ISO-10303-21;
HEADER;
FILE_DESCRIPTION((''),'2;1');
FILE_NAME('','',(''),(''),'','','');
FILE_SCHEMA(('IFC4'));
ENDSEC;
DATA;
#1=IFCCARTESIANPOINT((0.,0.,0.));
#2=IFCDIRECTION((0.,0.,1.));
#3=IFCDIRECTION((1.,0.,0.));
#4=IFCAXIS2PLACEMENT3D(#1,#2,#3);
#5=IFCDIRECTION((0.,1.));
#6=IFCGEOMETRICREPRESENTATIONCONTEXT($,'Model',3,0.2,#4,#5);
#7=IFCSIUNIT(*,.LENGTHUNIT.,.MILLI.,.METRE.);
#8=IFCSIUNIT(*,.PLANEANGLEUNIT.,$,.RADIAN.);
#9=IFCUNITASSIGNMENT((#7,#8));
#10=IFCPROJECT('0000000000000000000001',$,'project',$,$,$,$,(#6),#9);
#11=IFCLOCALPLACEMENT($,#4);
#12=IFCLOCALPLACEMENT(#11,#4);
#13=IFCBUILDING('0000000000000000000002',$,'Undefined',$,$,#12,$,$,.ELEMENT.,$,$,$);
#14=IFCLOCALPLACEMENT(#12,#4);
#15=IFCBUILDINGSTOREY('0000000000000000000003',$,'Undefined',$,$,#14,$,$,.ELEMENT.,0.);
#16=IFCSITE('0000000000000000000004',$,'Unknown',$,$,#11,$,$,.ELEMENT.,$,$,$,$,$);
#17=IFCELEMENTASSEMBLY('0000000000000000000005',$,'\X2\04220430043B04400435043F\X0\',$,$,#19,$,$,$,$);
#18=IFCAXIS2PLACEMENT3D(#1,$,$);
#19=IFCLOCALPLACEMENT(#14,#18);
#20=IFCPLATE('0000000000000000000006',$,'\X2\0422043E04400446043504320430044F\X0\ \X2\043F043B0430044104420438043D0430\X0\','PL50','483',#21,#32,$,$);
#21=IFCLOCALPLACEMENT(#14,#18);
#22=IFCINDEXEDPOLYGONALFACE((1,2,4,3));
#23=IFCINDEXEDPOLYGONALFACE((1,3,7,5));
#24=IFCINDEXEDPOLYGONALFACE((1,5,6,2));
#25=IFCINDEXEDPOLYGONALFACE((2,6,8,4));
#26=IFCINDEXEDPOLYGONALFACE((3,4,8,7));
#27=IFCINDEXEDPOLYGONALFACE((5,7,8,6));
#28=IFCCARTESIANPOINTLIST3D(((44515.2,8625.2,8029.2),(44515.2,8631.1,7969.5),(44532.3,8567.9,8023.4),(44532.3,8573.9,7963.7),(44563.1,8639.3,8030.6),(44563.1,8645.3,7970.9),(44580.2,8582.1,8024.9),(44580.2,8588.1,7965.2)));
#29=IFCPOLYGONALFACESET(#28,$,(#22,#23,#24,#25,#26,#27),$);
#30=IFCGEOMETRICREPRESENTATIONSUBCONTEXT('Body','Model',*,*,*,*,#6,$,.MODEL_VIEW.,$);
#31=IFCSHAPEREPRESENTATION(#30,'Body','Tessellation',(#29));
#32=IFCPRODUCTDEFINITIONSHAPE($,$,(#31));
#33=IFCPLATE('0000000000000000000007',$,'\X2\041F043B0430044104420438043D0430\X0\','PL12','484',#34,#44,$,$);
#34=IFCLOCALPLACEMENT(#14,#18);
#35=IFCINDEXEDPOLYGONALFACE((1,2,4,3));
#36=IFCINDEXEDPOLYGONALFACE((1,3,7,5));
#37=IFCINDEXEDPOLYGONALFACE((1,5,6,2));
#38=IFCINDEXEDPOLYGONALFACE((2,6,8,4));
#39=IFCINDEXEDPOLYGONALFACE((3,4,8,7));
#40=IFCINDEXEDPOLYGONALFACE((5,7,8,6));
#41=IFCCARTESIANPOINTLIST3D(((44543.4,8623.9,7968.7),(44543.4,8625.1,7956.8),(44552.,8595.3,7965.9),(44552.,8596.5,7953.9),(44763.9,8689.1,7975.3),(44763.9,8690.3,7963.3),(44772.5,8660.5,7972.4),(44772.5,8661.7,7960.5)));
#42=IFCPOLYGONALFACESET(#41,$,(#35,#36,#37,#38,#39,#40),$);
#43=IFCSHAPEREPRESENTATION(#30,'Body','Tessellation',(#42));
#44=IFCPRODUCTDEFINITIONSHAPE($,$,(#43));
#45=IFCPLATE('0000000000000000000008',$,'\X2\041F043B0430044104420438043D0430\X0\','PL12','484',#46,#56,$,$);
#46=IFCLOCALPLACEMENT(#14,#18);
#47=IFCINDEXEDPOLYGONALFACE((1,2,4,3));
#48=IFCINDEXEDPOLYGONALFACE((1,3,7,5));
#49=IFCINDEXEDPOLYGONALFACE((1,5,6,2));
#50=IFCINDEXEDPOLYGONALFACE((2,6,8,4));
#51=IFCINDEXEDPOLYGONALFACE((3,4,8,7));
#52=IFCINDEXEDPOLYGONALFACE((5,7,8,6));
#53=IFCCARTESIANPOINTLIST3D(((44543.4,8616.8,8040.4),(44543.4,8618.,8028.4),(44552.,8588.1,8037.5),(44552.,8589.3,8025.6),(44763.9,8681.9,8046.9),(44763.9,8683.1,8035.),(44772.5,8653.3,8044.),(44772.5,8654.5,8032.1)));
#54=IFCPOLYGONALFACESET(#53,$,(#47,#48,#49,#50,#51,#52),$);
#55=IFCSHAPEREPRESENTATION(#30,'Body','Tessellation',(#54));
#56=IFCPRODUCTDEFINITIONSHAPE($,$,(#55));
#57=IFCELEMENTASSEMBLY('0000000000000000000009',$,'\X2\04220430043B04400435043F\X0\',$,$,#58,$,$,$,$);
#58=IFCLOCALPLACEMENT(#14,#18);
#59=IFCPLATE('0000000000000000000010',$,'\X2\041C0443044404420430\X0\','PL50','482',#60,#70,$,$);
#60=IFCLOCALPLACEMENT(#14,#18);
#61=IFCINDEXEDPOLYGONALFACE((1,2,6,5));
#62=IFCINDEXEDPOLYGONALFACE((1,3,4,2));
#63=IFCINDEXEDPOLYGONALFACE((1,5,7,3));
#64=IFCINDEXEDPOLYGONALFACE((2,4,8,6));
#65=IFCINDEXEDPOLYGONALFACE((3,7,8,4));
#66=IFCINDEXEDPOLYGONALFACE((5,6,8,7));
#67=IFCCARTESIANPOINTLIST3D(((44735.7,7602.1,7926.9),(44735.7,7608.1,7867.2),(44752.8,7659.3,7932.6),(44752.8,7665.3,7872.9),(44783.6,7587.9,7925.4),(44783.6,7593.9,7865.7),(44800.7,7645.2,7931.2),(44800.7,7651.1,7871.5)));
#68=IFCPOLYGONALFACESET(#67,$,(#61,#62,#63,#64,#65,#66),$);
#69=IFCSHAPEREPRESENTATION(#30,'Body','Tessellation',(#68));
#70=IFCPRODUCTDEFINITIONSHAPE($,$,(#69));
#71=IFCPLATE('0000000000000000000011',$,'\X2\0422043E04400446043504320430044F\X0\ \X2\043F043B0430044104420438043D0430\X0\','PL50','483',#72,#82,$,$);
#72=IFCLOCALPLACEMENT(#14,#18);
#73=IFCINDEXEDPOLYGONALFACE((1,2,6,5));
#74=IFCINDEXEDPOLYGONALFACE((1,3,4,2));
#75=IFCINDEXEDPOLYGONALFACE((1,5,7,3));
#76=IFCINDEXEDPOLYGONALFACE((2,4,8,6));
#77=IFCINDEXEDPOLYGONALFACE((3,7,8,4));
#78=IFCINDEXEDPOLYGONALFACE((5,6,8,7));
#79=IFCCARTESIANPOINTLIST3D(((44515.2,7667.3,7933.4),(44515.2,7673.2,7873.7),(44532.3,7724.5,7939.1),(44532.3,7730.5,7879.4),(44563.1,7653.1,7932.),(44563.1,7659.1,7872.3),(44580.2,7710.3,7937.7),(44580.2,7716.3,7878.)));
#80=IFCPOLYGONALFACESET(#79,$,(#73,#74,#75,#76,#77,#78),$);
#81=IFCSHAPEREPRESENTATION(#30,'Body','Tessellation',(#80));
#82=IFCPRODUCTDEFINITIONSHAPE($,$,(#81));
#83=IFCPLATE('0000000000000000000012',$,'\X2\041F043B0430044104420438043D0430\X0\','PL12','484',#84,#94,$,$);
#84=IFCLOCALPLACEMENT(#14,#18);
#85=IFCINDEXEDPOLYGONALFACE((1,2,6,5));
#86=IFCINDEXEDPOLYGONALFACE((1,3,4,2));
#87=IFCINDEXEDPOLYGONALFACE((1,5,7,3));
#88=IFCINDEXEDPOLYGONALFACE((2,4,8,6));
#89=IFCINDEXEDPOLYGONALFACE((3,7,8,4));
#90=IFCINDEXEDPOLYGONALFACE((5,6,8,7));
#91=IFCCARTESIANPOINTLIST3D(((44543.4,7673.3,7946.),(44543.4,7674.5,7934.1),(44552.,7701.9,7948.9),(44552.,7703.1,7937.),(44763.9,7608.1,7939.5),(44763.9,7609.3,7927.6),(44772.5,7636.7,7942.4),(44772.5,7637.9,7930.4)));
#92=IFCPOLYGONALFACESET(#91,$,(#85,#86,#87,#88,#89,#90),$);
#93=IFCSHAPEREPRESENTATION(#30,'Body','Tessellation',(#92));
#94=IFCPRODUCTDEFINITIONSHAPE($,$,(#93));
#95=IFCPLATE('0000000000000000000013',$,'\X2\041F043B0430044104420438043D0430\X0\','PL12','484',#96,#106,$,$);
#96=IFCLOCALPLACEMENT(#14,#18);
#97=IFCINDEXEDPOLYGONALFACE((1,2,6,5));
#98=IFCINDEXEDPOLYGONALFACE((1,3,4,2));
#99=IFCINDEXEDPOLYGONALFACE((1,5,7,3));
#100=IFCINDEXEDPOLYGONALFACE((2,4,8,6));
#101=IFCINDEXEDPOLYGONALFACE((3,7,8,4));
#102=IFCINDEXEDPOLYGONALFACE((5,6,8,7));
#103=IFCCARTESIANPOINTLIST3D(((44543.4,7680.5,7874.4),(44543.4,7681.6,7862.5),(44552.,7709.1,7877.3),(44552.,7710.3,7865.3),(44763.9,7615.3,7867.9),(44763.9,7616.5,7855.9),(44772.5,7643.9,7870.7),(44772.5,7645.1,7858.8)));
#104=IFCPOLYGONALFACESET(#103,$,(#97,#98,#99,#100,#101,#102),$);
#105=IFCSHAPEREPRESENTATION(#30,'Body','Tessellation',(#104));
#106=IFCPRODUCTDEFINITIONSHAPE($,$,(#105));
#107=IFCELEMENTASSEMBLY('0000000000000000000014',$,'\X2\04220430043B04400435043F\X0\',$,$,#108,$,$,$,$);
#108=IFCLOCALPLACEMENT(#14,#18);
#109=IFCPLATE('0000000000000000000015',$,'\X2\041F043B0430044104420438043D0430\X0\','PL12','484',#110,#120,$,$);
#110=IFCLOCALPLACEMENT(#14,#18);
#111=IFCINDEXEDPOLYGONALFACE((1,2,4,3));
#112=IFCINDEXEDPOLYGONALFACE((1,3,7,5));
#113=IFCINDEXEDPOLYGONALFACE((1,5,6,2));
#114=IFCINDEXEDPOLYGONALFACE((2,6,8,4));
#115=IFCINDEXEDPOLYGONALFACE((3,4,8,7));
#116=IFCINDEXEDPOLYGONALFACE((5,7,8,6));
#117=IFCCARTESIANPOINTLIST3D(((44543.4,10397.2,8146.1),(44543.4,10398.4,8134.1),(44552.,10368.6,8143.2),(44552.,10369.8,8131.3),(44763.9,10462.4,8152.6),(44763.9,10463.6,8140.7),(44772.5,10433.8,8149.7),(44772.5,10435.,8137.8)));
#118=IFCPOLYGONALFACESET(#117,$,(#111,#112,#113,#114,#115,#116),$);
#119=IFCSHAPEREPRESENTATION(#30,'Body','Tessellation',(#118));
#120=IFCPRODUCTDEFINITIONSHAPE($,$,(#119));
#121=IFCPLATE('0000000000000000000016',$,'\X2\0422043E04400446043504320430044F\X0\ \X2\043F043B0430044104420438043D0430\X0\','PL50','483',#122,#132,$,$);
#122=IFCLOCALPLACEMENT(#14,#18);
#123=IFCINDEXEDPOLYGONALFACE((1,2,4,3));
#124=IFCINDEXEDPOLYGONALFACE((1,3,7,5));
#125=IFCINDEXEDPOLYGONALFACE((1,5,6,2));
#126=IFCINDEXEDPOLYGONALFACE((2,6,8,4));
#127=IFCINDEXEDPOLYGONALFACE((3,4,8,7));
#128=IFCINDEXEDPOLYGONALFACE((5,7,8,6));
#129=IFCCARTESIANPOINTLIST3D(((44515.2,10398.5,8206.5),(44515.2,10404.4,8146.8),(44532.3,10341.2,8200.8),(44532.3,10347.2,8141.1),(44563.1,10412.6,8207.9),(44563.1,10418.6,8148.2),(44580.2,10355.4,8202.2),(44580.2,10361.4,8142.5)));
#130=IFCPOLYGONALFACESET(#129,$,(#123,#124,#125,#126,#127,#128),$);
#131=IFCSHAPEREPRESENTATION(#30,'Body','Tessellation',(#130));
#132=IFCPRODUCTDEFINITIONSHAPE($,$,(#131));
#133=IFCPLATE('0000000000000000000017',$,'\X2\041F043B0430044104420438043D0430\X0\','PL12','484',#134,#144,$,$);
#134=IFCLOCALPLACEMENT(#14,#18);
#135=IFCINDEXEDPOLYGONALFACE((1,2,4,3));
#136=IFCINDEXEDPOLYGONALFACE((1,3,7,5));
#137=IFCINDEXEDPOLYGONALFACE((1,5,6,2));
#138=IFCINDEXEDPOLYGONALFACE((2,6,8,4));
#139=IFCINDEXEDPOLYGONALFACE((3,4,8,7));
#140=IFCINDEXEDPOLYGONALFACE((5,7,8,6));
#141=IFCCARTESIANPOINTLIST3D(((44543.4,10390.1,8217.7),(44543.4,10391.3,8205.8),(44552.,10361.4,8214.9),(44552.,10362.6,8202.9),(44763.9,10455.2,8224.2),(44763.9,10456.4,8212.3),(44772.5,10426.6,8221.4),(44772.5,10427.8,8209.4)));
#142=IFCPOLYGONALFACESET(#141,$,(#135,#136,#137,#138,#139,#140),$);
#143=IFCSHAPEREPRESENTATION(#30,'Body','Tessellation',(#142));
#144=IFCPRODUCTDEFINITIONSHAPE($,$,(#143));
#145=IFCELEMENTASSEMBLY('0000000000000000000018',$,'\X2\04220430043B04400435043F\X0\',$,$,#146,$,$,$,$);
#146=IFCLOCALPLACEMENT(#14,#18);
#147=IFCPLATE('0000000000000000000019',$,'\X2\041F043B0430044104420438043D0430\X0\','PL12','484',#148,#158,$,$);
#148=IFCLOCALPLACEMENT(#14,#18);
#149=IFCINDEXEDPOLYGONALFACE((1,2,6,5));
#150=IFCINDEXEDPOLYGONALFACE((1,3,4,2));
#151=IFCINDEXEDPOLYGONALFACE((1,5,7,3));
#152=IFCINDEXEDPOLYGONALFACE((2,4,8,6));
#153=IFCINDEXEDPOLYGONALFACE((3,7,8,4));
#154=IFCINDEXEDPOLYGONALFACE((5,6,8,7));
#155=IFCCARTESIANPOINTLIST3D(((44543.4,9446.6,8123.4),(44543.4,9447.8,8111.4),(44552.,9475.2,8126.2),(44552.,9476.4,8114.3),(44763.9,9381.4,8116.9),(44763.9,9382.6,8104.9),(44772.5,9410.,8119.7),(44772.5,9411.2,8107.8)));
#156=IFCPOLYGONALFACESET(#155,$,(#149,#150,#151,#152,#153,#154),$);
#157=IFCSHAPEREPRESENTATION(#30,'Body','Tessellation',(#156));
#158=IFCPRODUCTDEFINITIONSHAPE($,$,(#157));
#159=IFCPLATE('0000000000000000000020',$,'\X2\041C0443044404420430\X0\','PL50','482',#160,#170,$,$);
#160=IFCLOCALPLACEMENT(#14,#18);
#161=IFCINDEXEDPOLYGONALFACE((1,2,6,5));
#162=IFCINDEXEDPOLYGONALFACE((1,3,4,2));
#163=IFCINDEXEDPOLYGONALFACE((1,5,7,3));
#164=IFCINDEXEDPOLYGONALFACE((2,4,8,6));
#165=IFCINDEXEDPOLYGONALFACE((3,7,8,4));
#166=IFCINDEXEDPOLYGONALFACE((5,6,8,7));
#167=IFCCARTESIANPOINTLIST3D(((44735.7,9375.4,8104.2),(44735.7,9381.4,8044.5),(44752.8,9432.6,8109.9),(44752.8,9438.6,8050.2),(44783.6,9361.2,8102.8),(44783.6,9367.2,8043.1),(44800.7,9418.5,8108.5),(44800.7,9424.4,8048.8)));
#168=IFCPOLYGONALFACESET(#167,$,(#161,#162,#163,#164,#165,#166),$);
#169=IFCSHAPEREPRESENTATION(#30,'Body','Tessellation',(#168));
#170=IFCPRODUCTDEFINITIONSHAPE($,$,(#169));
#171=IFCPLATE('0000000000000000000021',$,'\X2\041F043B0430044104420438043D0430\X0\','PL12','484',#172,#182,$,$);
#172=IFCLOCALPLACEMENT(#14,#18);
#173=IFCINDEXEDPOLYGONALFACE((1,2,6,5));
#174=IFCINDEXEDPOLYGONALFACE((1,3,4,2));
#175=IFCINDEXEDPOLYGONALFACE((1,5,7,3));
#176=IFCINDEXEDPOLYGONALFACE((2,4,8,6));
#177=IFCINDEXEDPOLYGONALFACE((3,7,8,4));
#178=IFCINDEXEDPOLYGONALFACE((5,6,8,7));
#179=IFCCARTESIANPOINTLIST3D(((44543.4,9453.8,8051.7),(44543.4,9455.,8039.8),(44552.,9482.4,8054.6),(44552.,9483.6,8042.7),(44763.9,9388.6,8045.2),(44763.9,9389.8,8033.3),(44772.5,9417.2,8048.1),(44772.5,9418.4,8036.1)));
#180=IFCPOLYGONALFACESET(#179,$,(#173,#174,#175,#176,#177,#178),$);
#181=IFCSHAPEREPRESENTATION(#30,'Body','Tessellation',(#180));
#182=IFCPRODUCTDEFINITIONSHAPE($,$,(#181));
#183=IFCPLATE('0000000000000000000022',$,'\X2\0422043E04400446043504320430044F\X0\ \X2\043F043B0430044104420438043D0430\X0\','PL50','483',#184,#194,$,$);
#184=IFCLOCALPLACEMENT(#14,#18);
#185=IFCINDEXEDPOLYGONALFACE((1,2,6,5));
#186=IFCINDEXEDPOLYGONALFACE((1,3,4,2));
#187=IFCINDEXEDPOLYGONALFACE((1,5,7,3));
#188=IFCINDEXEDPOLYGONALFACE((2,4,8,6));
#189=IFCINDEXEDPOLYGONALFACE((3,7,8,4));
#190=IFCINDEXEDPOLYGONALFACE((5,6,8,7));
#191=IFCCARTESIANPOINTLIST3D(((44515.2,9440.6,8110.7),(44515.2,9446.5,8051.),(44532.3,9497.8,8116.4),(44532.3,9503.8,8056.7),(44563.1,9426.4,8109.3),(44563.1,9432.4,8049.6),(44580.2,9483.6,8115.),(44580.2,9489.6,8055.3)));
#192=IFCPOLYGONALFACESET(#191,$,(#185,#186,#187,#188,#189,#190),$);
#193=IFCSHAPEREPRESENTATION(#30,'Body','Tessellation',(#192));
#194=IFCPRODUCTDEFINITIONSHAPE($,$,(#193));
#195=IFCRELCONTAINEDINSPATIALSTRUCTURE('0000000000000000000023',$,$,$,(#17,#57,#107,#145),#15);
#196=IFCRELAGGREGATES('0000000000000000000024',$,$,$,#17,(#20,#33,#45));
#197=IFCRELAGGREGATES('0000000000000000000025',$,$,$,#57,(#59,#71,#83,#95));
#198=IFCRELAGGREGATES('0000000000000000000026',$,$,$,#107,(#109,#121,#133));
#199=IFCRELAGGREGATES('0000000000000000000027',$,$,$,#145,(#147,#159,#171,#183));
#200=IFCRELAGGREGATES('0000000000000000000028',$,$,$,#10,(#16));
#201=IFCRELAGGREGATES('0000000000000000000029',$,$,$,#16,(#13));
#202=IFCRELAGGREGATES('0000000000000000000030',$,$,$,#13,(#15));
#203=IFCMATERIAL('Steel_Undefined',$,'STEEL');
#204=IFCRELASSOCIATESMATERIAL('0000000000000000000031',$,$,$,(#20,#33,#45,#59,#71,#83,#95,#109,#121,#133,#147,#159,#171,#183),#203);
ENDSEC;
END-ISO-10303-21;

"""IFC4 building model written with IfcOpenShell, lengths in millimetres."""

from ifc_helpers import new_model, si_unit, direction, frame, origin_with_axes, place, context, subcontext, project, spatial, line, indexed_curve, outline, extrude, material, element, aggregate, save


model = new_model("IFC4")

# Units and contexts
model_context = context("Model", 3, precision=0.2, world=origin_with_axes(), true_north=direction((0.0, 1.0)))
body_context = subcontext(model_context, "Body", "Model", "MODEL_VIEW")
ifc_project = project(units=[si_unit("LENGTHUNIT", "METRE", prefix="MILLI"), si_unit("PLANEANGLEUNIT", "RADIAN")], contexts=[model_context])

# Site, building, storey
site_placement = place(None, origin_with_axes())
site = spatial("IfcSite", under=ifc_project, at=site_placement, Name="Unknown", CompositionType="ELEMENT")
building_placement = place(site_placement, origin_with_axes())
building = spatial("IfcBuilding", under=site, at=building_placement, Name="Undefined", CompositionType="ELEMENT")
storey_placement = place(building_placement, origin_with_axes())
storey = spatial("IfcBuildingStorey", under=building, at=storey_placement, Name="Undefined", CompositionType="ELEMENT", Elevation=0.0)

# Element assemblies, plates
assembly_1_placement = place(storey_placement, frame((44776.7, 8640.2, 8030.7), z_axis=(-0.958608, -0.283317, -0.028332), x_axis=(-0.28473, 0.95385, 0.095385)))
assembly_1 = element("IfcElementAssembly", 1, at=assembly_1_placement, inside=storey, Name="Талреп")
ifc_material_1 = material(Name="Steel_Undefined", Category="STEEL")
plate_1_placement = place(assembly_1_placement, frame((0.0, 0.0, 230.0), z_axis=(0.0, 0.0, 1.0), x_axis=(1.0, 0.0, 0.0)))
plate_1 = element("IfcPlate", 2, at=plate_1_placement, material=ifc_material_1, Name="Торцевая пластина", Description="PL50", ObjectType="483", context=body_context, shape_type="SolidModel", body=[
    extrude(outline(indexed_curve([(0.0, 0.0), (60.0, 0.0), (60.0, 60.0), (0.0, 60.0)], segments=[line(1, 2, 3, 4, 1)])), frame((0.0, 0.0, 25.0), z_axis=(0.0, 0.0, 1.0), x_axis=(1.0, 0.0, 0.0)), (0.0, 0.0, -1.0), 50.0),
])
plate_2_placement = place(assembly_1_placement, frame((15.0, 66.0, 230.0), z_axis=(0.0, 1.0, 0.0), x_axis=(1.0, 0.0, 0.0)))
plate_2 = element("IfcPlate", 3, at=plate_2_placement, material=ifc_material_1, Name="Пластина", Description="PL12", ObjectType="484", context=body_context, shape_type="SolidModel", body=[
    extrude(outline(indexed_curve([(0.0, 0.0), (30.0, 0.0), (30.0, 230.0), (0.0, 230.0)], segments=[line(1, 2, 3, 4, 1)])), frame((0.0, 0.0, 6.0), z_axis=(0.0, 0.0, 1.0), x_axis=(1.0, 0.0, 0.0)), (0.0, 0.0, -1.0), 12.0),
])
plate_3_placement = place(assembly_1_placement, frame((15.0, -6.0, 230.0), z_axis=(0.0, 1.0, 0.0), x_axis=(1.0, 0.0, 0.0)))
plate_3 = element("IfcPlate", 4, at=plate_3_placement, material=ifc_material_1, Name="Пластина", Description="PL12", ObjectType="484", context=body_context, shape_type="SolidModel", body=[
    extrude(outline(indexed_curve([(0.0, 0.0), (30.0, 0.0), (30.0, 230.0), (0.0, 230.0)], segments=[line(1, 2, 3, 4, 1)])), frame((0.0, 0.0, 6.0), z_axis=(0.0, 0.0, 1.0), x_axis=(1.0, 0.0, 0.0)), (0.0, 0.0, -1.0), 12.0),
])
assembly_2_placement = place(storey_placement, frame((44759.6, 7595.0, 7926.2), z_axis=(-0.958608, 0.283317, 0.028332), x_axis=(0.28473, 0.95385, 0.095385)))
assembly_2 = element("IfcElementAssembly", 5, at=assembly_2_placement, inside=storey, Name="Талреп")
plate_4_placement = place(assembly_2_placement, origin_with_axes())
plate_4 = element("IfcPlate", 6, at=plate_4_placement, material=ifc_material_1, Name="Муфта", Description="PL50", ObjectType="482", context=body_context, shape_type="SolidModel", body=[
    extrude(outline(indexed_curve([(0.0, 0.0), (60.0, 0.0), (60.0, 60.0), (0.0, 60.0)], segments=[line(1, 2, 3, 4, 1)])), frame((0.0, 0.0, 25.0), z_axis=(0.0, 0.0, 1.0), x_axis=(1.0, 0.0, 0.0)), (0.0, 0.0, -1.0), 50.0),
])
plate_5_placement = place(assembly_2_placement, frame((0.0, 0.0, 230.0), z_axis=(0.0, 0.0, 1.0), x_axis=(1.0, 0.0, 0.0)))
plate_5 = element("IfcPlate", 7, at=plate_5_placement, material=ifc_material_1, Name="Торцевая пластина", Description="PL50", ObjectType="483", context=body_context, shape_type="SolidModel", body=[
    extrude(outline(indexed_curve([(0.0, 0.0), (60.0, 0.0), (60.0, 60.0), (0.0, 60.0)], segments=[line(1, 2, 3, 4, 1)])), frame((0.0, 0.0, 25.0), z_axis=(0.0, 0.0, 1.0), x_axis=(1.0, 0.0, 0.0)), (0.0, 0.0, -1.0), 50.0),
])
plate_6_placement = place(assembly_2_placement, frame((15.0, -6.0, 230.0), z_axis=(0.0, 1.0, 0.0), x_axis=(1.0, 0.0, 0.0)))
plate_6 = element("IfcPlate", 8, at=plate_6_placement, material=ifc_material_1, Name="Пластина", Description="PL12", ObjectType="484", context=body_context, shape_type="SolidModel", body=[
    extrude(outline(indexed_curve([(0.0, 0.0), (30.0, 0.0), (30.0, 230.0), (0.0, 230.0)], segments=[line(1, 2, 3, 4, 1)])), frame((0.0, 0.0, 6.0), z_axis=(0.0, 0.0, 1.0), x_axis=(1.0, 0.0, 0.0)), (0.0, 0.0, -1.0), 12.0),
])
plate_7_placement = place(assembly_2_placement, frame((15.0, 66.0, 230.0), z_axis=(0.0, 1.0, 0.0), x_axis=(1.0, 0.0, 0.0)))
plate_7 = element("IfcPlate", 9, at=plate_7_placement, material=ifc_material_1, Name="Пластина", Description="PL12", ObjectType="484", context=body_context, shape_type="SolidModel", body=[
    extrude(outline(indexed_curve([(0.0, 0.0), (30.0, 0.0), (30.0, 230.0), (0.0, 230.0)], segments=[line(1, 2, 3, 4, 1)])), frame((0.0, 0.0, 6.0), z_axis=(0.0, 0.0, 1.0), x_axis=(1.0, 0.0, 0.0)), (0.0, 0.0, -1.0), 12.0),
])
assembly_3_placement = place(storey_placement, frame((44776.7, 10413.5, 8208.0), z_axis=(-0.958608, -0.283317, -0.028332), x_axis=(-0.28473, 0.95385, 0.095385)))
assembly_3 = element("IfcElementAssembly", 10, at=assembly_3_placement, inside=storey, Name="Талреп")
plate_8_placement = place(assembly_3_placement, frame((15.0, 66.0, 230.0), z_axis=(0.0, 1.0, 0.0), x_axis=(1.0, 0.0, 0.0)))
plate_8 = element("IfcPlate", 11, at=plate_8_placement, material=ifc_material_1, Name="Пластина", Description="PL12", ObjectType="484", context=body_context, shape_type="SolidModel", body=[
    extrude(outline(indexed_curve([(0.0, 0.0), (30.0, 0.0), (30.0, 230.0), (0.0, 230.0)], segments=[line(1, 2, 3, 4, 1)])), frame((0.0, 0.0, 6.0), z_axis=(0.0, 0.0, 1.0), x_axis=(1.0, 0.0, 0.0)), (0.0, 0.0, -1.0), 12.0),
])
plate_9_placement = place(assembly_3_placement, frame((0.0, 0.0, 230.0), z_axis=(0.0, 0.0, 1.0), x_axis=(1.0, 0.0, 0.0)))
plate_9 = element("IfcPlate", 12, at=plate_9_placement, material=ifc_material_1, Name="Торцевая пластина", Description="PL50", ObjectType="483", context=body_context, shape_type="SolidModel", body=[
    extrude(outline(indexed_curve([(0.0, 0.0), (60.0, 0.0), (60.0, 60.0), (0.0, 60.0)], segments=[line(1, 2, 3, 4, 1)])), frame((0.0, 0.0, 25.0), z_axis=(0.0, 0.0, 1.0), x_axis=(1.0, 0.0, 0.0)), (0.0, 0.0, -1.0), 50.0),
])
plate_10_placement = place(assembly_3_placement, frame((15.0, -6.0, 230.0), z_axis=(0.0, 1.0, 0.0), x_axis=(1.0, 0.0, 0.0)))
plate_10 = element("IfcPlate", 13, at=plate_10_placement, material=ifc_material_1, Name="Пластина", Description="PL12", ObjectType="484", context=body_context, shape_type="SolidModel", body=[
    extrude(outline(indexed_curve([(0.0, 0.0), (30.0, 0.0), (30.0, 230.0), (0.0, 230.0)], segments=[line(1, 2, 3, 4, 1)])), frame((0.0, 0.0, 6.0), z_axis=(0.0, 0.0, 1.0), x_axis=(1.0, 0.0, 0.0)), (0.0, 0.0, -1.0), 12.0),
])
assembly_4_placement = place(storey_placement, frame((44759.6, 9368.3, 8103.5), z_axis=(-0.958608, 0.283317, 0.028332), x_axis=(0.28473, 0.95385, 0.095385)))
assembly_4 = element("IfcElementAssembly", 14, at=assembly_4_placement, inside=storey, Name="Талреп")
plate_11_placement = place(assembly_4_placement, frame((15.0, -6.0, 230.0), z_axis=(0.0, 1.0, 0.0), x_axis=(1.0, 0.0, 0.0)))
plate_11 = element("IfcPlate", 15, at=plate_11_placement, material=ifc_material_1, Name="Пластина", Description="PL12", ObjectType="484", context=body_context, shape_type="SolidModel", body=[
    extrude(outline(indexed_curve([(0.0, 0.0), (30.0, 0.0), (30.0, 230.0), (0.0, 230.0)], segments=[line(1, 2, 3, 4, 1)])), frame((0.0, 0.0, 6.0), z_axis=(0.0, 0.0, 1.0), x_axis=(1.0, 0.0, 0.0)), (0.0, 0.0, -1.0), 12.0),
])
plate_12_placement = place(assembly_4_placement, origin_with_axes())
plate_12 = element("IfcPlate", 16, at=plate_12_placement, material=ifc_material_1, Name="Муфта", Description="PL50", ObjectType="482", context=body_context, shape_type="SolidModel", body=[
    extrude(outline(indexed_curve([(0.0, 0.0), (60.0, 0.0), (60.0, 60.0), (0.0, 60.0)], segments=[line(1, 2, 3, 4, 1)])), frame((0.0, 0.0, 25.0), z_axis=(0.0, 0.0, 1.0), x_axis=(1.0, 0.0, 0.0)), (0.0, 0.0, -1.0), 50.0),
])
plate_13_placement = place(assembly_4_placement, frame((15.0, 66.0, 230.0), z_axis=(0.0, 1.0, 0.0), x_axis=(1.0, 0.0, 0.0)))
plate_13 = element("IfcPlate", 17, at=plate_13_placement, material=ifc_material_1, Name="Пластина", Description="PL12", ObjectType="484", context=body_context, shape_type="SolidModel", body=[
    extrude(outline(indexed_curve([(0.0, 0.0), (30.0, 0.0), (30.0, 230.0), (0.0, 230.0)], segments=[line(1, 2, 3, 4, 1)])), frame((0.0, 0.0, 6.0), z_axis=(0.0, 0.0, 1.0), x_axis=(1.0, 0.0, 0.0)), (0.0, 0.0, -1.0), 12.0),
])
plate_14_placement = place(assembly_4_placement, frame((0.0, 0.0, 230.0), z_axis=(0.0, 0.0, 1.0), x_axis=(1.0, 0.0, 0.0)))
plate_14 = element("IfcPlate", 18, at=plate_14_placement, material=ifc_material_1, Name="Торцевая пластина", Description="PL50", ObjectType="483", context=body_context, shape_type="SolidModel", body=[
    extrude(outline(indexed_curve([(0.0, 0.0), (60.0, 0.0), (60.0, 60.0), (0.0, 60.0)], segments=[line(1, 2, 3, 4, 1)])), frame((0.0, 0.0, 25.0), z_axis=(0.0, 0.0, 1.0), x_axis=(1.0, 0.0, 0.0)), (0.0, 0.0, -1.0), 50.0),
])

aggregate(assembly_1, [plate_1, plate_2, plate_3])
aggregate(assembly_2, [plate_4, plate_5, plate_6, plate_7])
aggregate(assembly_3, [plate_8, plate_9, plate_10])
aggregate(assembly_4, [plate_11, plate_12, plate_13, plate_14])

save(model, "model.ifc")
